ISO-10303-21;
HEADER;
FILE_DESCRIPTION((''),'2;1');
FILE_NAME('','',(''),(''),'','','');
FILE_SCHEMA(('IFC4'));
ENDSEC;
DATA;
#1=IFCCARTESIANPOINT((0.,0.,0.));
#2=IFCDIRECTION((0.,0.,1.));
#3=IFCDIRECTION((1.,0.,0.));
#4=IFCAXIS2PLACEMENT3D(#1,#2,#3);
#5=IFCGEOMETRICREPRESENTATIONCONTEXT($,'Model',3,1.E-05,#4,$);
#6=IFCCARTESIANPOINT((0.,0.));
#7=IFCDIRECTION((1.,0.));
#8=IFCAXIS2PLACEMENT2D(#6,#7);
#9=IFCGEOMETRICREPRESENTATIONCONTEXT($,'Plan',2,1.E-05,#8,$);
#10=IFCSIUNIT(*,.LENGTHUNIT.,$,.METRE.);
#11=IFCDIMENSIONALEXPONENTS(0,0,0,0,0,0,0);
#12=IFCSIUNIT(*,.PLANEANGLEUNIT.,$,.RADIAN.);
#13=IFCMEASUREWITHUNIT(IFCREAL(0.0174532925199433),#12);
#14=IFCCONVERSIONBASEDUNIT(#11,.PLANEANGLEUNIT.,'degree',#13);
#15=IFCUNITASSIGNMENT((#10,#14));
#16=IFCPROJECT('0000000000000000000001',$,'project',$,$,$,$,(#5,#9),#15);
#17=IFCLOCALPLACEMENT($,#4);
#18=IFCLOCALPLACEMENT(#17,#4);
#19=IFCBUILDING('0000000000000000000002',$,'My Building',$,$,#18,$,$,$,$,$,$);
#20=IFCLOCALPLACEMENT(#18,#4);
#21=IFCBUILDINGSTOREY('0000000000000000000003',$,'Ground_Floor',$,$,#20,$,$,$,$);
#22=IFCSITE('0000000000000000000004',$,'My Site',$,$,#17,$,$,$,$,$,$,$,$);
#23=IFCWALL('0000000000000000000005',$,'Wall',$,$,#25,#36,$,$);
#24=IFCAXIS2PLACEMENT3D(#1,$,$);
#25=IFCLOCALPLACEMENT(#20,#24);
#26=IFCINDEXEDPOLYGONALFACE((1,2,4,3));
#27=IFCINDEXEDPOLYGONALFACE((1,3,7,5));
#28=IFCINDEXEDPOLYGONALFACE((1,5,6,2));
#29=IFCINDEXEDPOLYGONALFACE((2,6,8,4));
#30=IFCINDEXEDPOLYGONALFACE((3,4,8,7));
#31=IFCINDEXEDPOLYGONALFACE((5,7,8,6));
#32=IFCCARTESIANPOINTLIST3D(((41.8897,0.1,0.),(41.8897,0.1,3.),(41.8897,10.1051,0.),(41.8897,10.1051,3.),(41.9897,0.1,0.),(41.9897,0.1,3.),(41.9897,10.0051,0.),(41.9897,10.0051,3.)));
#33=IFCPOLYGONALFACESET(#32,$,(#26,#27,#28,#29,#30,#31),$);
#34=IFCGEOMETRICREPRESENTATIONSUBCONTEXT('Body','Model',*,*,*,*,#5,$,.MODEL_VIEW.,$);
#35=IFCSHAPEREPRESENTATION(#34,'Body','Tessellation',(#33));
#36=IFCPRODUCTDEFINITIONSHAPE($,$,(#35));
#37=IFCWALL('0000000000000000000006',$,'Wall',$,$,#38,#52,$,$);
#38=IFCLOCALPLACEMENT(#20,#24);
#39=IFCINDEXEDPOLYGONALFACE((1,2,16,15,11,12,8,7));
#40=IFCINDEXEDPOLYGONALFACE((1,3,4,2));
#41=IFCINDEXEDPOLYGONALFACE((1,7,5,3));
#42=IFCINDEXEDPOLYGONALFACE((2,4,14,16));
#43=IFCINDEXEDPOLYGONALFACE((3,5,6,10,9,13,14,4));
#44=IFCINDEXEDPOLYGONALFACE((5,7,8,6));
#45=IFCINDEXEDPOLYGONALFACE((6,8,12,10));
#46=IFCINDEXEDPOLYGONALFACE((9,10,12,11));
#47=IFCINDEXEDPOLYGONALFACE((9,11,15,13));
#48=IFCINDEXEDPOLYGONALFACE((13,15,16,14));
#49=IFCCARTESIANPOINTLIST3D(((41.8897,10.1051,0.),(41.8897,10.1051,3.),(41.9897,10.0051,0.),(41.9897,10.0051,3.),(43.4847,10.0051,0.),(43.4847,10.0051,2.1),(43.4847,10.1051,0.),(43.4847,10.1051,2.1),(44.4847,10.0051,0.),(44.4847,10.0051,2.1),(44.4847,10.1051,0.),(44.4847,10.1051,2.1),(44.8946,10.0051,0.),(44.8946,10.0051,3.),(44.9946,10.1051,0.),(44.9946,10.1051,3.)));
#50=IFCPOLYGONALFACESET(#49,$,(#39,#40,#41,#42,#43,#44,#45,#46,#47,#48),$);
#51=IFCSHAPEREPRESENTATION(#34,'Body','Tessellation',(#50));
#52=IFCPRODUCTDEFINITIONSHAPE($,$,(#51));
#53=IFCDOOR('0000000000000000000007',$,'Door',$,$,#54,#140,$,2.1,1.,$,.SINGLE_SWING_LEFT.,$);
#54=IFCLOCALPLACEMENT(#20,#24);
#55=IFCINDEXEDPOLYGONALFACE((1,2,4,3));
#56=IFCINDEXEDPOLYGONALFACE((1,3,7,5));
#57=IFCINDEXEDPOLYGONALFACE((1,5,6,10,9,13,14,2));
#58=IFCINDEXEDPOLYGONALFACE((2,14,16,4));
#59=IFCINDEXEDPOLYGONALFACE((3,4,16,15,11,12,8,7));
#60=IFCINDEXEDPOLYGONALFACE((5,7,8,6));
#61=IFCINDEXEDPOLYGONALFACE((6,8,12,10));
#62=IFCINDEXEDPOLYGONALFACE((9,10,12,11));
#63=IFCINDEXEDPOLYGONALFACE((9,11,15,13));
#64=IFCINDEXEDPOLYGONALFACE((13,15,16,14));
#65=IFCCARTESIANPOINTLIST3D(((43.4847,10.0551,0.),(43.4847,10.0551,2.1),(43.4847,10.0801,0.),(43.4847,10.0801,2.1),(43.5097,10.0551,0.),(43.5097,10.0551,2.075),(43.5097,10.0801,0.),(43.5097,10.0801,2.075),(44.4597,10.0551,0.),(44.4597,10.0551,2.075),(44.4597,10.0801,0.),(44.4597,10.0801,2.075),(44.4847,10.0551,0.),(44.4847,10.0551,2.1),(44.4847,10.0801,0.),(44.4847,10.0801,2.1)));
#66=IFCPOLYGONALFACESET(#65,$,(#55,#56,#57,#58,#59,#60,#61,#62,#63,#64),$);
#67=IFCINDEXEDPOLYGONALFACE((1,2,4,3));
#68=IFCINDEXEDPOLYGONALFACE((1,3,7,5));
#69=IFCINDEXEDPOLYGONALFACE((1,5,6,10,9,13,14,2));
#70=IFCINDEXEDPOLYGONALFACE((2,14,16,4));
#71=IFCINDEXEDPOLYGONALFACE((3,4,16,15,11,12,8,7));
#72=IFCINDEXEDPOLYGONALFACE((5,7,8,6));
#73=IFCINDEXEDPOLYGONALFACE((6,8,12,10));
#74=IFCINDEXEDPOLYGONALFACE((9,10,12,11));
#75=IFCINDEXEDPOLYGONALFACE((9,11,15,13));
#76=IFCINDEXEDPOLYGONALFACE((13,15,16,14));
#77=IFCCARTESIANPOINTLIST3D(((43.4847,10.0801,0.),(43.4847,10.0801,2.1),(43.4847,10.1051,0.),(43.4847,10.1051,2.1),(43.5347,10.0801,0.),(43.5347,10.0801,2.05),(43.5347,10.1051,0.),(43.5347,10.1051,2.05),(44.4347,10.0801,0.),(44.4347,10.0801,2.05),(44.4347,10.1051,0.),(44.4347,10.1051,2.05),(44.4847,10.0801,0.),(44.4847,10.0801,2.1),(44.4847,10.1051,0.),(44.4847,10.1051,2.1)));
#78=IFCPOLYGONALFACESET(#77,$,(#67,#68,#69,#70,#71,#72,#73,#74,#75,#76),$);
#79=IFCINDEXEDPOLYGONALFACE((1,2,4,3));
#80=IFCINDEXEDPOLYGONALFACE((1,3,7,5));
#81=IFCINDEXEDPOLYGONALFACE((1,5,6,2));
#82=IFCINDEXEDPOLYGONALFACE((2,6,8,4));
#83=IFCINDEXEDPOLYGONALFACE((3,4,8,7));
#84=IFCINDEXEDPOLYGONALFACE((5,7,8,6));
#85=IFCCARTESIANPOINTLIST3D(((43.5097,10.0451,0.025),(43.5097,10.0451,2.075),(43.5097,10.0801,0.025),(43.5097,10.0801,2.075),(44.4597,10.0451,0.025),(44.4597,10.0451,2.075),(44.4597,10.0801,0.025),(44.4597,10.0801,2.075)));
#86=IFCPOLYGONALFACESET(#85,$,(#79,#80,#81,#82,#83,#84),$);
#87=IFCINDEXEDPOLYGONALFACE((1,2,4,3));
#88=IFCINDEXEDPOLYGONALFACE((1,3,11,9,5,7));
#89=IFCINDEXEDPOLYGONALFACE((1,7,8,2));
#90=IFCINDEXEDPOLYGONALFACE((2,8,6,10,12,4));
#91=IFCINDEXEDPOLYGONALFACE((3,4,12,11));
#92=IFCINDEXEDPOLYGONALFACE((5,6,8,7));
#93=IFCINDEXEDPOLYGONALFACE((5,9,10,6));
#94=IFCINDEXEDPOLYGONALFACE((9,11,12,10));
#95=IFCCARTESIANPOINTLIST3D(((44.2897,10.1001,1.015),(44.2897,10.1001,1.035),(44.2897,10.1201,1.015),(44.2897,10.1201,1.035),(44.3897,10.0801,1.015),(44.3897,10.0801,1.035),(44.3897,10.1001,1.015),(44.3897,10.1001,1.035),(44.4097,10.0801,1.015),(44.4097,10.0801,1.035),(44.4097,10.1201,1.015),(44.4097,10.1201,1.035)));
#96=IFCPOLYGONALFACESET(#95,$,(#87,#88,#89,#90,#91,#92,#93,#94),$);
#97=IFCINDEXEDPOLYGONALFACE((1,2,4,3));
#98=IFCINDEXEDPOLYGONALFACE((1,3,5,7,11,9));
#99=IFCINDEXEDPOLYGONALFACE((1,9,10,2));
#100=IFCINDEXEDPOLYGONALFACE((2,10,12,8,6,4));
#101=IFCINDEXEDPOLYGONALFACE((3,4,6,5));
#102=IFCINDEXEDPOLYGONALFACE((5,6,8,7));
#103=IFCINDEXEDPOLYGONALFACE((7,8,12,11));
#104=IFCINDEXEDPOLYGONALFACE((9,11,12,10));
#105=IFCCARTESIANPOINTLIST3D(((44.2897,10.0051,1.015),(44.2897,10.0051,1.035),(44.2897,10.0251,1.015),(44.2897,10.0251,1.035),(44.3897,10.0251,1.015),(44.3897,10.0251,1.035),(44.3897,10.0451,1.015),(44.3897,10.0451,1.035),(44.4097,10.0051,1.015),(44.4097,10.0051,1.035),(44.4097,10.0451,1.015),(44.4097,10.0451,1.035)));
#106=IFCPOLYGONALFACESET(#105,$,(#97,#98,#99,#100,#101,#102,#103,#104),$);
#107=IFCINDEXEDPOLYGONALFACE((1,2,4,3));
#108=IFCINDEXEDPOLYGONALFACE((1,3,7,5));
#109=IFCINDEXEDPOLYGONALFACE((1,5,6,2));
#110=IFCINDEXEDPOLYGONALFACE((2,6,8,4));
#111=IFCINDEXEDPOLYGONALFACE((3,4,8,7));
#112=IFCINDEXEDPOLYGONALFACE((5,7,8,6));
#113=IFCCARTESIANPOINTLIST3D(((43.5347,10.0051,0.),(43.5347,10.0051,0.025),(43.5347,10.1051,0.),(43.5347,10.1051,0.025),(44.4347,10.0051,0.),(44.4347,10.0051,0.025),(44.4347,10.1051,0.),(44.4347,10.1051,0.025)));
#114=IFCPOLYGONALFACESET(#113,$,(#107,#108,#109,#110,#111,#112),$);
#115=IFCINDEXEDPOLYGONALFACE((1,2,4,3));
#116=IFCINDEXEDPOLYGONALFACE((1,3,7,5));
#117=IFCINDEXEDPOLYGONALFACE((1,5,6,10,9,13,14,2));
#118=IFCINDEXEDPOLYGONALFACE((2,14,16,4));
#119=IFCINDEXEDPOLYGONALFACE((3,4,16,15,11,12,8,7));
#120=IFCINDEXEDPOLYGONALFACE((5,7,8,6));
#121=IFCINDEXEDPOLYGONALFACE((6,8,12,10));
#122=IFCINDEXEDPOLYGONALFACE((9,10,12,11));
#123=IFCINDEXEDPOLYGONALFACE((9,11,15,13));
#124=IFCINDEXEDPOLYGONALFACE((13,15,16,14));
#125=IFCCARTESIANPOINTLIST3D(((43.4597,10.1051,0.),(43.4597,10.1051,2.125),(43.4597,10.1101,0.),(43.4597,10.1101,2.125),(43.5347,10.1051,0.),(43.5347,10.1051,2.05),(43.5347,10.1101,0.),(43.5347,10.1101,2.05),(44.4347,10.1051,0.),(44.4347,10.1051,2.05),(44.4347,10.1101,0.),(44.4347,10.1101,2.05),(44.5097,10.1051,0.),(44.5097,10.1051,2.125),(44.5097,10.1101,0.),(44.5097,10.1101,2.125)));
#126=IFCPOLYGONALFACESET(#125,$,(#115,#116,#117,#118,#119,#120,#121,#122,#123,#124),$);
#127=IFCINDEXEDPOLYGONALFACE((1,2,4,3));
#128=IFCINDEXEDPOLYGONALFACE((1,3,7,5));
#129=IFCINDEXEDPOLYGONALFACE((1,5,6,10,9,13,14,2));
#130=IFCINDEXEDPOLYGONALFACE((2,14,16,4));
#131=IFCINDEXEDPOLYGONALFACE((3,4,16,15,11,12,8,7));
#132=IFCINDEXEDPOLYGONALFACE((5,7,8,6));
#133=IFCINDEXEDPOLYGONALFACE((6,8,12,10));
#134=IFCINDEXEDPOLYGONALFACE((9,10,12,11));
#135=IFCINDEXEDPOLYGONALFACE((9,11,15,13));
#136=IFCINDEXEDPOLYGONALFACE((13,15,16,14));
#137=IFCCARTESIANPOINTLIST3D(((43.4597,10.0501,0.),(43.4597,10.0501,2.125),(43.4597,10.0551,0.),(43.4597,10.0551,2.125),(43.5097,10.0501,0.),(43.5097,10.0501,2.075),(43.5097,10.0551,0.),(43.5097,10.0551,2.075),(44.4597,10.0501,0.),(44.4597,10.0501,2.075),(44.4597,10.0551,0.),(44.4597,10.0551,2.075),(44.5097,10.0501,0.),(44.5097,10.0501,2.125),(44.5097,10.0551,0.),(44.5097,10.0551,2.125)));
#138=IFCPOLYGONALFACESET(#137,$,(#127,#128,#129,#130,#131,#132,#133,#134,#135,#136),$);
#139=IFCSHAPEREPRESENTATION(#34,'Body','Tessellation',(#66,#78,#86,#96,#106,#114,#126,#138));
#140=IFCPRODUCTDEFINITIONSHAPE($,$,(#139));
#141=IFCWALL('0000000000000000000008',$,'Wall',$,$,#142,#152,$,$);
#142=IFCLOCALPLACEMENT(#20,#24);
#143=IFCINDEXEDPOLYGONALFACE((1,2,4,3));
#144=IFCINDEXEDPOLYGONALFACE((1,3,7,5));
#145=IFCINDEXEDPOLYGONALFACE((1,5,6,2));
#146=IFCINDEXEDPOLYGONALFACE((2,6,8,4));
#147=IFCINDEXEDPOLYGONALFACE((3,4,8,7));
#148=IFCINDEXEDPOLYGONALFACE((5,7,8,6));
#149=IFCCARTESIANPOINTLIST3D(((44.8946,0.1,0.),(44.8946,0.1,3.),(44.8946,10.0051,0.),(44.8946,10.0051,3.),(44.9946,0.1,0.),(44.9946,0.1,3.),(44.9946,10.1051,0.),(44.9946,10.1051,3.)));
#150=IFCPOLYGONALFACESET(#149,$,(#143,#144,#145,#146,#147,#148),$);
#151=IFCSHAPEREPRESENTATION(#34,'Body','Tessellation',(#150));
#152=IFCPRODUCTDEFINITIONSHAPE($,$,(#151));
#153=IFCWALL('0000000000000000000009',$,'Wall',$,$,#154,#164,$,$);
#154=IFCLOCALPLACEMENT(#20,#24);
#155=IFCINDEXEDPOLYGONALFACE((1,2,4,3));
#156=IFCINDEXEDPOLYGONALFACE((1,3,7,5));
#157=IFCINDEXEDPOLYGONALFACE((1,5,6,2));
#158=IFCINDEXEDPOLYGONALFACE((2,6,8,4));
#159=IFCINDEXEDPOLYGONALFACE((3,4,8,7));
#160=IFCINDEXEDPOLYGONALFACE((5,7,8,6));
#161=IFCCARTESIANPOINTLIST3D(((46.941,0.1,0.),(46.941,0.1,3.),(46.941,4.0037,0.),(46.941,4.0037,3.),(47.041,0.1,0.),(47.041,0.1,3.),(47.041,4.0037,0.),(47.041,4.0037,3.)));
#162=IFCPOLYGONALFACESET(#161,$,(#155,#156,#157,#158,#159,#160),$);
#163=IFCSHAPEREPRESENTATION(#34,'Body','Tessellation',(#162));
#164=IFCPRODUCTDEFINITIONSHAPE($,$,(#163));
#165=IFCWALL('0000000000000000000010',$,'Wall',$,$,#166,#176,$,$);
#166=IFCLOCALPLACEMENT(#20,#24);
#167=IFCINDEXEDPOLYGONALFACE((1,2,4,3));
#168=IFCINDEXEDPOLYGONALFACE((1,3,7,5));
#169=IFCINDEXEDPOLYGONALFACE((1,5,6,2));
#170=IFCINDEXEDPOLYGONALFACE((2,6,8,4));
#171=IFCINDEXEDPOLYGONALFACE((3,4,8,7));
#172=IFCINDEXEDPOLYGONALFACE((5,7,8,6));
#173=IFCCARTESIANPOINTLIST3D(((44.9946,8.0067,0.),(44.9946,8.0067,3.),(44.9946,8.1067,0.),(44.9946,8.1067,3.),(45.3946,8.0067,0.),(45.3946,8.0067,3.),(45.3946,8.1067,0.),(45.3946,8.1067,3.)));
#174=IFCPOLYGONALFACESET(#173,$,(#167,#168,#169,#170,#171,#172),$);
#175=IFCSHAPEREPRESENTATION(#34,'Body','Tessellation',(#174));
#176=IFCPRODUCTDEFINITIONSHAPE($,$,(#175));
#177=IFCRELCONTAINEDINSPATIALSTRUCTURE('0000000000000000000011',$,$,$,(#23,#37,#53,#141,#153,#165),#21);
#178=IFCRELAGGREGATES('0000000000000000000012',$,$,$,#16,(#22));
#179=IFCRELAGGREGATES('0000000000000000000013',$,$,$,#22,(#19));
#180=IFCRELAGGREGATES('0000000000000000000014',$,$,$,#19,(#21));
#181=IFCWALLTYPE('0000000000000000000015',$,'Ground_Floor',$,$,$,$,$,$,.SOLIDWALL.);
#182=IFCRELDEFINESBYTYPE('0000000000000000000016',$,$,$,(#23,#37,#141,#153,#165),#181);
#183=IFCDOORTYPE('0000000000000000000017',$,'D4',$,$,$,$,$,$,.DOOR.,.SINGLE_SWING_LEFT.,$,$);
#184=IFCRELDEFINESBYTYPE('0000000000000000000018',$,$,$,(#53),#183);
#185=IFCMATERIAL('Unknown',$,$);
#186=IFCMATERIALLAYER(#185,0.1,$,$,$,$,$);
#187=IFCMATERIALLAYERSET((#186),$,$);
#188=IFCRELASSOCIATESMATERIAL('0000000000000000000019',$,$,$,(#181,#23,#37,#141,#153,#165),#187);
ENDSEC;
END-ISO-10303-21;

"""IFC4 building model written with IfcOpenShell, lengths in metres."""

from ifc_helpers import new_model, entity, si_unit, converted_unit, frame, origin_with_axes, origin_2d_with_axis, place, context, subcontext, project, spatial, line, indexed_curve, outline, extrude, shape, source, transform, mapped, material, layer, layer_set, layer_usage, type_object, type_shapes, element, fill, save


model = new_model("IFC4")

# Units and contexts
model_context = context("Model", 3, precision=1e-05, world=origin_with_axes())
plan_context = context("Plan", 2, precision=1e-05, world=origin_2d_with_axis())
body_context_1 = subcontext(model_context, "Body", "Model", "MODEL_VIEW")
body_context_2 = subcontext(plan_context, "Body", "Plan", "PLAN_VIEW")
ifc_project = project(units=[si_unit("LENGTHUNIT", "METRE"), converted_unit("PLANEANGLEUNIT", "degree", entity("IfcReal", 0.0174532925199433), si_unit("PLANEANGLEUNIT", "RADIAN"), dimensions=[0, 0, 0, 0, 0, 0, 0])], contexts=[model_context, plan_context])

# Site, building, storey
site_placement = place(None, origin_with_axes())
site = spatial("IfcSite", under=ifc_project, at=site_placement, Name="My Site")
building_placement = place(site_placement, origin_with_axes())
building = spatial("IfcBuilding", under=site, at=building_placement, Name="My Building")
storey_placement = place(building_placement, origin_with_axes())
storey = spatial("IfcBuildingStorey", under=building, at=storey_placement, Name="Ground_Floor")

# Shared definitions
ifc_material = material(Name="Unknown")

# Shared definitions
ifc_layer = layer(ifc_material, 0.1)
ifc_layer_set = layer_set([ifc_layer])
wall_type = type_object("IfcWallType", Name="Ground_Floor", PredefinedType="SOLIDWALL", material=ifc_layer_set)

# Wall
ifc_layer_usage_1 = layer_usage(ifc_layer_set, "AXIS2", "POSITIVE", 0.0)
wall_1_placement = place(storey_placement, frame((41.9897, 0.1, 0.0), z_axis=(0.0, 0.0, 1.0), x_axis=(0.0, 1.0, 0.0)))
element("IfcWall", 1, at=wall_1_placement, inside=storey, type_object=wall_type, material=ifc_layer_usage_1, Name="Wall", context=body_context_1, shape_type="SweptSolid", body=[
    extrude(outline(indexed_curve([(0.0, 0.0), (0.0, 0.1), (10.0051, 0.1), (9.9051, 0.0)], segments=[line(1, 2, 3, 4, 1)])), origin_with_axes(), (0.0, 0.0, 1.0), 3.0),
])

# Wall, opening, door
ifc_layer_usage_2 = layer_usage(ifc_layer_set, "AXIS2", "POSITIVE", 0.0)
wall_2_placement = place(storey_placement, frame((41.9897, 10.0051, 0.0), z_axis=(0.0, 0.0, 1.0), x_axis=(1.0, 0.0, 0.0)))
wall_2 = element("IfcWall", 2, at=wall_2_placement, inside=storey, type_object=wall_type, material=ifc_layer_usage_2, Name="Wall", context=body_context_1, shape_type="SweptSolid", body=[
    extrude(outline(indexed_curve([(0.0, 0.0), (-0.1, 0.1), (3.0049, 0.1), (2.9049, 0.0)], segments=[line(1, 2, 3, 4, 1)])), origin_with_axes(), (0.0, 0.0, 1.0), 3.0),
])
shared_shape_1 = source(origin_with_axes(), body_context_1, "Body", "SweptSolid", [
    extrude(outline(indexed_curve([(0.0, 0.0), (1.0, 0.0), (1.0, 2.1), (0.0, 2.1)], segments=[line(1, 2, 3, 4, 1)])), frame((0.0, -0.6, 0.0), z_axis=(0.0, -1.0, 0.0), x_axis=(1.0, 0.0, 0.0)), (0.0, 0.0, -1.0), 1.2),
])
opening_1_placement = place(wall_2_placement, frame((2.495, 0.1, 0.0), z_axis=(0.0, 0.0, 1.0), x_axis=(-1.0, 0.0, 0.0)))
opening_1 = element("IfcOpeningElement", 3, at=opening_1_placement, cuts=wall_2, PredefinedType="OPENING", context=body_context_1, shape_type="MappedRepresentation", body=[
    mapped(shared_shape_1, transform((0.0, 0.0, 0.0), x_axis=(1.0, 0.0, 0.0), y_axis=(0.0, 1.0, 0.0), z_axis=(0.0, 0.0, 1.0), scale=1.0)),
])
door_type = type_object("IfcDoorType", Name="D4", OperationType="SINGLE_SWING_LEFT", PredefinedType="DOOR")
shared_shape_2 = source(origin_with_axes(), body_context_1, "Body", "SweptSolid", [
    extrude(outline(indexed_curve([(0.0, 0.0), (0.0, 2.1), (1.0, 2.1), (1.0, 0.0), (0.975, 0.0), (0.975, 2.075), (0.025, 2.075), (0.025, 0.0)], segments=[line(1, 2, 3, 4, 5, 6, 7, 8, 1)])), frame((0.0, 0.025, 0.0), z_axis=(0.0, -1.0, 0.0), x_axis=(1.0, 0.0, 0.0)), (0.0, 0.0, -1.0), 0.025),
    extrude(outline(indexed_curve([(0.0, 0.0), (0.0, 2.1), (1.0, 2.1), (1.0, 0.0), (0.95, 0.0), (0.95, 2.05), (0.05, 2.05), (0.05, 0.0)], segments=[line(1, 2, 3, 4, 5, 6, 7, 8, 1)])), frame((0.0, 0.0, 0.0), z_axis=(0.0, -1.0, 0.0), x_axis=(1.0, 0.0, 0.0)), (0.0, 0.0, -1.0), 0.025),
    extrude(outline(indexed_curve([(0.0, 0.0), (0.95, 0.0), (0.95, 0.035), (0.0, 0.035)], segments=[line(1, 2, 3, 4, 1)])), frame((0.025, 0.025, 0.025), z_axis=(0.0, 0.0, 1.0), x_axis=(1.0, 0.0, 0.0)), (0.0, 0.0, 1.0), 2.05),
    extrude(outline(indexed_curve([(0.0, 0.0), (0.0, -0.04), (0.12, -0.04), (0.12, -0.02), (0.02, -0.02), (0.02, 0.0)], segments=[line(1, 2, 3, 4, 5, 6, 1)])), frame((0.075, 0.025, 1.015), z_axis=(0.0, 0.0, 1.0), x_axis=(1.0, 0.0, 0.0)), (0.0, 0.0, 1.0), 0.02),
    extrude(outline(indexed_curve([(0.0, 0.0), (0.0, 0.04), (0.12, 0.04), (0.12, 0.02), (0.02, 0.02), (0.02, 0.0)], segments=[line(1, 2, 3, 4, 5, 6, 1)])), frame((0.075, 0.06, 1.015), z_axis=(0.0, 0.0, 1.0), x_axis=(1.0, 0.0, 0.0)), (0.0, 0.0, 1.0), 0.02),
    extrude(outline(indexed_curve([(0.0, 0.0), (0.9, 0.0), (0.9, 0.1), (0.0, 0.1)], segments=[line(1, 2, 3, 4, 1)])), frame((0.05, 0.0, 0.0), z_axis=(0.0, 0.0, 1.0), x_axis=(1.0, 0.0, 0.0)), (0.0, 0.0, 1.0), 0.025),
    extrude(outline(indexed_curve([(0.0, 0.0), (0.0, 2.125), (1.05, 2.125), (1.05, 0.0), (0.975, 0.0), (0.975, 2.05), (0.075, 2.05), (0.075, 0.0)], segments=[line(1, 2, 3, 4, 5, 6, 7, 8, 1)])), frame((-0.025, -0.005, 0.0), z_axis=(0.0, -1.0, 0.0), x_axis=(1.0, 0.0, 0.0)), (0.0, 0.0, -1.0), 0.005),
    extrude(outline(indexed_curve([(0.0, 0.0), (0.0, 2.125), (1.05, 2.125), (1.05, 0.0), (1.0, 0.0), (1.0, 2.075), (0.05, 2.075), (0.05, 0.0)], segments=[line(1, 2, 3, 4, 5, 6, 7, 8, 1)])), frame((-0.025, 0.05, 0.0), z_axis=(0.0, -1.0, 0.0), x_axis=(1.0, 0.0, 0.0)), (0.0, 0.0, -1.0), 0.005),
])
shared_shape_3 = source(origin_with_axes(), body_context_2, "Body", "Curve2D", [
    entity("IfcIndexedPolyCurve", entity("IfcCartesianPointList2D", [[0.0, 0.0], [0.0, 0.05], [0.025, 0.05], [0.025, 0.025], [0.05, 0.025], [0.05, 0.0]]), [entity("IfcLineIndex", [1, 2, 3, 4, 5, 6, 1])]),
    entity("IfcIndexedPolyCurve", entity("IfcCartesianPointList2D", [[1.0, 0.0], [1.0, 0.05], [0.975, 0.05], [0.975, 0.025], [0.95, 0.025], [0.95, 0.0]]), [entity("IfcLineIndex", [1, 2, 3, 4, 5, 6, 1])]),
    entity("IfcTrimmedCurve", entity("IfcEllipse", entity("IfcAxis2Placement2D", entity("IfcCartesianPoint", [0.94, 0.05]), entity("IfcDirection", [1.0, 0.0])), 0.915, 0.95), [entity("IfcCartesianPoint", [0.94, 1.0])], [entity("IfcCartesianPoint", [0.025, 0.05])], True, "CARTESIAN"),
    entity("IfcIndexedPolyCurve", entity("IfcCartesianPointList2D", [[0.975, 0.05], [0.94, 0.05], [0.94, 1.0], [0.975, 1.0]]), [entity("IfcLineIndex", [1, 2, 3, 4, 1])]),
])
type_shapes(door_type, [shared_shape_2, shared_shape_3])
door_placement = place(opening_1_placement, origin_with_axes())
door = element("IfcDoor", 4, at=door_placement, inside=storey, type_object=door_type, Name="Door", OperationType="SINGLE_SWING_LEFT", OverallHeight=2.1, OverallWidth=1.0, shapes=[
    shape(body_context_1, "Body", "MappedRepresentation", [mapped(shared_shape_2, transform((0.0, 0.0, 0.0), x_axis=(1.0, 0.0, 0.0), y_axis=(0.0, 1.0, 0.0), z_axis=(0.0, 0.0, 1.0), scale=1.0))]),
    shape(body_context_2, "Body", "MappedRepresentation", [mapped(shared_shape_3, transform((0.0, 0.0, 0.0), x_axis=(1.0, 0.0, 0.0), y_axis=(0.0, 1.0, 0.0), z_axis=(0.0, 0.0, 1.0), scale=1.0))]),
])
fill(opening_1, door)

# Walls
ifc_layer_usage_3 = layer_usage(ifc_layer_set, "AXIS2", "POSITIVE", 0.0)
wall_3_placement = place(storey_placement, frame((44.8946, 10.0051, 0.0), z_axis=(0.0, 0.0, 1.0), x_axis=(0.0, -1.0, 0.0)))
element("IfcWall", 5, at=wall_3_placement, inside=storey, type_object=wall_type, material=ifc_layer_usage_3, Name="Wall", context=body_context_1, shape_type="SweptSolid", body=[
    extrude(outline(indexed_curve([(0.0, 0.0), (-0.1, 0.1), (9.9052, 0.1), (9.9052, 0.0)], segments=[line(1, 2, 3, 4, 1)])), origin_with_axes(), (0.0, 0.0, 1.0), 3.0),
])
ifc_layer_usage_4 = layer_usage(ifc_layer_set, "AXIS2", "POSITIVE", 0.0)
wall_4_placement = place(storey_placement, frame((46.941, 4.0037, 0.0), z_axis=(0.0, 0.0, 1.0), x_axis=(0.0, -1.0, 0.0)))
element("IfcWall", 6, at=wall_4_placement, inside=storey, type_object=wall_type, material=ifc_layer_usage_4, Name="Wall", context=body_context_1, shape_type="SweptSolid", body=[
    extrude(outline(indexed_curve([(0.0, 0.0), (0.0, 0.1), (3.9038, 0.1), (3.9038, 0.0)], segments=[line(1, 2, 3, 4, 1)])), origin_with_axes(), (0.0, 0.0, 1.0), 3.0),
])
ifc_layer_usage_5 = layer_usage(ifc_layer_set, "AXIS2", "POSITIVE", 0.0)
wall_5_placement = place(storey_placement, frame((44.9946, 8.0067, 0.0), z_axis=(0.0, 0.0, 1.0), x_axis=(1.0, 0.0, 0.0)))
element("IfcWall", 7, at=wall_5_placement, inside=storey, type_object=wall_type, material=ifc_layer_usage_5, Name="Wall", context=body_context_1, shape_type="SweptSolid", body=[
    extrude(outline(indexed_curve([(0.0, 0.0), (0.0, 0.1), (0.4, 0.1), (0.4, 0.0)], segments=[line(1, 2, 3, 4, 1)])), origin_with_axes(), (0.0, 0.0, 1.0), 3.0),
])

save(model, "model.ifc")
